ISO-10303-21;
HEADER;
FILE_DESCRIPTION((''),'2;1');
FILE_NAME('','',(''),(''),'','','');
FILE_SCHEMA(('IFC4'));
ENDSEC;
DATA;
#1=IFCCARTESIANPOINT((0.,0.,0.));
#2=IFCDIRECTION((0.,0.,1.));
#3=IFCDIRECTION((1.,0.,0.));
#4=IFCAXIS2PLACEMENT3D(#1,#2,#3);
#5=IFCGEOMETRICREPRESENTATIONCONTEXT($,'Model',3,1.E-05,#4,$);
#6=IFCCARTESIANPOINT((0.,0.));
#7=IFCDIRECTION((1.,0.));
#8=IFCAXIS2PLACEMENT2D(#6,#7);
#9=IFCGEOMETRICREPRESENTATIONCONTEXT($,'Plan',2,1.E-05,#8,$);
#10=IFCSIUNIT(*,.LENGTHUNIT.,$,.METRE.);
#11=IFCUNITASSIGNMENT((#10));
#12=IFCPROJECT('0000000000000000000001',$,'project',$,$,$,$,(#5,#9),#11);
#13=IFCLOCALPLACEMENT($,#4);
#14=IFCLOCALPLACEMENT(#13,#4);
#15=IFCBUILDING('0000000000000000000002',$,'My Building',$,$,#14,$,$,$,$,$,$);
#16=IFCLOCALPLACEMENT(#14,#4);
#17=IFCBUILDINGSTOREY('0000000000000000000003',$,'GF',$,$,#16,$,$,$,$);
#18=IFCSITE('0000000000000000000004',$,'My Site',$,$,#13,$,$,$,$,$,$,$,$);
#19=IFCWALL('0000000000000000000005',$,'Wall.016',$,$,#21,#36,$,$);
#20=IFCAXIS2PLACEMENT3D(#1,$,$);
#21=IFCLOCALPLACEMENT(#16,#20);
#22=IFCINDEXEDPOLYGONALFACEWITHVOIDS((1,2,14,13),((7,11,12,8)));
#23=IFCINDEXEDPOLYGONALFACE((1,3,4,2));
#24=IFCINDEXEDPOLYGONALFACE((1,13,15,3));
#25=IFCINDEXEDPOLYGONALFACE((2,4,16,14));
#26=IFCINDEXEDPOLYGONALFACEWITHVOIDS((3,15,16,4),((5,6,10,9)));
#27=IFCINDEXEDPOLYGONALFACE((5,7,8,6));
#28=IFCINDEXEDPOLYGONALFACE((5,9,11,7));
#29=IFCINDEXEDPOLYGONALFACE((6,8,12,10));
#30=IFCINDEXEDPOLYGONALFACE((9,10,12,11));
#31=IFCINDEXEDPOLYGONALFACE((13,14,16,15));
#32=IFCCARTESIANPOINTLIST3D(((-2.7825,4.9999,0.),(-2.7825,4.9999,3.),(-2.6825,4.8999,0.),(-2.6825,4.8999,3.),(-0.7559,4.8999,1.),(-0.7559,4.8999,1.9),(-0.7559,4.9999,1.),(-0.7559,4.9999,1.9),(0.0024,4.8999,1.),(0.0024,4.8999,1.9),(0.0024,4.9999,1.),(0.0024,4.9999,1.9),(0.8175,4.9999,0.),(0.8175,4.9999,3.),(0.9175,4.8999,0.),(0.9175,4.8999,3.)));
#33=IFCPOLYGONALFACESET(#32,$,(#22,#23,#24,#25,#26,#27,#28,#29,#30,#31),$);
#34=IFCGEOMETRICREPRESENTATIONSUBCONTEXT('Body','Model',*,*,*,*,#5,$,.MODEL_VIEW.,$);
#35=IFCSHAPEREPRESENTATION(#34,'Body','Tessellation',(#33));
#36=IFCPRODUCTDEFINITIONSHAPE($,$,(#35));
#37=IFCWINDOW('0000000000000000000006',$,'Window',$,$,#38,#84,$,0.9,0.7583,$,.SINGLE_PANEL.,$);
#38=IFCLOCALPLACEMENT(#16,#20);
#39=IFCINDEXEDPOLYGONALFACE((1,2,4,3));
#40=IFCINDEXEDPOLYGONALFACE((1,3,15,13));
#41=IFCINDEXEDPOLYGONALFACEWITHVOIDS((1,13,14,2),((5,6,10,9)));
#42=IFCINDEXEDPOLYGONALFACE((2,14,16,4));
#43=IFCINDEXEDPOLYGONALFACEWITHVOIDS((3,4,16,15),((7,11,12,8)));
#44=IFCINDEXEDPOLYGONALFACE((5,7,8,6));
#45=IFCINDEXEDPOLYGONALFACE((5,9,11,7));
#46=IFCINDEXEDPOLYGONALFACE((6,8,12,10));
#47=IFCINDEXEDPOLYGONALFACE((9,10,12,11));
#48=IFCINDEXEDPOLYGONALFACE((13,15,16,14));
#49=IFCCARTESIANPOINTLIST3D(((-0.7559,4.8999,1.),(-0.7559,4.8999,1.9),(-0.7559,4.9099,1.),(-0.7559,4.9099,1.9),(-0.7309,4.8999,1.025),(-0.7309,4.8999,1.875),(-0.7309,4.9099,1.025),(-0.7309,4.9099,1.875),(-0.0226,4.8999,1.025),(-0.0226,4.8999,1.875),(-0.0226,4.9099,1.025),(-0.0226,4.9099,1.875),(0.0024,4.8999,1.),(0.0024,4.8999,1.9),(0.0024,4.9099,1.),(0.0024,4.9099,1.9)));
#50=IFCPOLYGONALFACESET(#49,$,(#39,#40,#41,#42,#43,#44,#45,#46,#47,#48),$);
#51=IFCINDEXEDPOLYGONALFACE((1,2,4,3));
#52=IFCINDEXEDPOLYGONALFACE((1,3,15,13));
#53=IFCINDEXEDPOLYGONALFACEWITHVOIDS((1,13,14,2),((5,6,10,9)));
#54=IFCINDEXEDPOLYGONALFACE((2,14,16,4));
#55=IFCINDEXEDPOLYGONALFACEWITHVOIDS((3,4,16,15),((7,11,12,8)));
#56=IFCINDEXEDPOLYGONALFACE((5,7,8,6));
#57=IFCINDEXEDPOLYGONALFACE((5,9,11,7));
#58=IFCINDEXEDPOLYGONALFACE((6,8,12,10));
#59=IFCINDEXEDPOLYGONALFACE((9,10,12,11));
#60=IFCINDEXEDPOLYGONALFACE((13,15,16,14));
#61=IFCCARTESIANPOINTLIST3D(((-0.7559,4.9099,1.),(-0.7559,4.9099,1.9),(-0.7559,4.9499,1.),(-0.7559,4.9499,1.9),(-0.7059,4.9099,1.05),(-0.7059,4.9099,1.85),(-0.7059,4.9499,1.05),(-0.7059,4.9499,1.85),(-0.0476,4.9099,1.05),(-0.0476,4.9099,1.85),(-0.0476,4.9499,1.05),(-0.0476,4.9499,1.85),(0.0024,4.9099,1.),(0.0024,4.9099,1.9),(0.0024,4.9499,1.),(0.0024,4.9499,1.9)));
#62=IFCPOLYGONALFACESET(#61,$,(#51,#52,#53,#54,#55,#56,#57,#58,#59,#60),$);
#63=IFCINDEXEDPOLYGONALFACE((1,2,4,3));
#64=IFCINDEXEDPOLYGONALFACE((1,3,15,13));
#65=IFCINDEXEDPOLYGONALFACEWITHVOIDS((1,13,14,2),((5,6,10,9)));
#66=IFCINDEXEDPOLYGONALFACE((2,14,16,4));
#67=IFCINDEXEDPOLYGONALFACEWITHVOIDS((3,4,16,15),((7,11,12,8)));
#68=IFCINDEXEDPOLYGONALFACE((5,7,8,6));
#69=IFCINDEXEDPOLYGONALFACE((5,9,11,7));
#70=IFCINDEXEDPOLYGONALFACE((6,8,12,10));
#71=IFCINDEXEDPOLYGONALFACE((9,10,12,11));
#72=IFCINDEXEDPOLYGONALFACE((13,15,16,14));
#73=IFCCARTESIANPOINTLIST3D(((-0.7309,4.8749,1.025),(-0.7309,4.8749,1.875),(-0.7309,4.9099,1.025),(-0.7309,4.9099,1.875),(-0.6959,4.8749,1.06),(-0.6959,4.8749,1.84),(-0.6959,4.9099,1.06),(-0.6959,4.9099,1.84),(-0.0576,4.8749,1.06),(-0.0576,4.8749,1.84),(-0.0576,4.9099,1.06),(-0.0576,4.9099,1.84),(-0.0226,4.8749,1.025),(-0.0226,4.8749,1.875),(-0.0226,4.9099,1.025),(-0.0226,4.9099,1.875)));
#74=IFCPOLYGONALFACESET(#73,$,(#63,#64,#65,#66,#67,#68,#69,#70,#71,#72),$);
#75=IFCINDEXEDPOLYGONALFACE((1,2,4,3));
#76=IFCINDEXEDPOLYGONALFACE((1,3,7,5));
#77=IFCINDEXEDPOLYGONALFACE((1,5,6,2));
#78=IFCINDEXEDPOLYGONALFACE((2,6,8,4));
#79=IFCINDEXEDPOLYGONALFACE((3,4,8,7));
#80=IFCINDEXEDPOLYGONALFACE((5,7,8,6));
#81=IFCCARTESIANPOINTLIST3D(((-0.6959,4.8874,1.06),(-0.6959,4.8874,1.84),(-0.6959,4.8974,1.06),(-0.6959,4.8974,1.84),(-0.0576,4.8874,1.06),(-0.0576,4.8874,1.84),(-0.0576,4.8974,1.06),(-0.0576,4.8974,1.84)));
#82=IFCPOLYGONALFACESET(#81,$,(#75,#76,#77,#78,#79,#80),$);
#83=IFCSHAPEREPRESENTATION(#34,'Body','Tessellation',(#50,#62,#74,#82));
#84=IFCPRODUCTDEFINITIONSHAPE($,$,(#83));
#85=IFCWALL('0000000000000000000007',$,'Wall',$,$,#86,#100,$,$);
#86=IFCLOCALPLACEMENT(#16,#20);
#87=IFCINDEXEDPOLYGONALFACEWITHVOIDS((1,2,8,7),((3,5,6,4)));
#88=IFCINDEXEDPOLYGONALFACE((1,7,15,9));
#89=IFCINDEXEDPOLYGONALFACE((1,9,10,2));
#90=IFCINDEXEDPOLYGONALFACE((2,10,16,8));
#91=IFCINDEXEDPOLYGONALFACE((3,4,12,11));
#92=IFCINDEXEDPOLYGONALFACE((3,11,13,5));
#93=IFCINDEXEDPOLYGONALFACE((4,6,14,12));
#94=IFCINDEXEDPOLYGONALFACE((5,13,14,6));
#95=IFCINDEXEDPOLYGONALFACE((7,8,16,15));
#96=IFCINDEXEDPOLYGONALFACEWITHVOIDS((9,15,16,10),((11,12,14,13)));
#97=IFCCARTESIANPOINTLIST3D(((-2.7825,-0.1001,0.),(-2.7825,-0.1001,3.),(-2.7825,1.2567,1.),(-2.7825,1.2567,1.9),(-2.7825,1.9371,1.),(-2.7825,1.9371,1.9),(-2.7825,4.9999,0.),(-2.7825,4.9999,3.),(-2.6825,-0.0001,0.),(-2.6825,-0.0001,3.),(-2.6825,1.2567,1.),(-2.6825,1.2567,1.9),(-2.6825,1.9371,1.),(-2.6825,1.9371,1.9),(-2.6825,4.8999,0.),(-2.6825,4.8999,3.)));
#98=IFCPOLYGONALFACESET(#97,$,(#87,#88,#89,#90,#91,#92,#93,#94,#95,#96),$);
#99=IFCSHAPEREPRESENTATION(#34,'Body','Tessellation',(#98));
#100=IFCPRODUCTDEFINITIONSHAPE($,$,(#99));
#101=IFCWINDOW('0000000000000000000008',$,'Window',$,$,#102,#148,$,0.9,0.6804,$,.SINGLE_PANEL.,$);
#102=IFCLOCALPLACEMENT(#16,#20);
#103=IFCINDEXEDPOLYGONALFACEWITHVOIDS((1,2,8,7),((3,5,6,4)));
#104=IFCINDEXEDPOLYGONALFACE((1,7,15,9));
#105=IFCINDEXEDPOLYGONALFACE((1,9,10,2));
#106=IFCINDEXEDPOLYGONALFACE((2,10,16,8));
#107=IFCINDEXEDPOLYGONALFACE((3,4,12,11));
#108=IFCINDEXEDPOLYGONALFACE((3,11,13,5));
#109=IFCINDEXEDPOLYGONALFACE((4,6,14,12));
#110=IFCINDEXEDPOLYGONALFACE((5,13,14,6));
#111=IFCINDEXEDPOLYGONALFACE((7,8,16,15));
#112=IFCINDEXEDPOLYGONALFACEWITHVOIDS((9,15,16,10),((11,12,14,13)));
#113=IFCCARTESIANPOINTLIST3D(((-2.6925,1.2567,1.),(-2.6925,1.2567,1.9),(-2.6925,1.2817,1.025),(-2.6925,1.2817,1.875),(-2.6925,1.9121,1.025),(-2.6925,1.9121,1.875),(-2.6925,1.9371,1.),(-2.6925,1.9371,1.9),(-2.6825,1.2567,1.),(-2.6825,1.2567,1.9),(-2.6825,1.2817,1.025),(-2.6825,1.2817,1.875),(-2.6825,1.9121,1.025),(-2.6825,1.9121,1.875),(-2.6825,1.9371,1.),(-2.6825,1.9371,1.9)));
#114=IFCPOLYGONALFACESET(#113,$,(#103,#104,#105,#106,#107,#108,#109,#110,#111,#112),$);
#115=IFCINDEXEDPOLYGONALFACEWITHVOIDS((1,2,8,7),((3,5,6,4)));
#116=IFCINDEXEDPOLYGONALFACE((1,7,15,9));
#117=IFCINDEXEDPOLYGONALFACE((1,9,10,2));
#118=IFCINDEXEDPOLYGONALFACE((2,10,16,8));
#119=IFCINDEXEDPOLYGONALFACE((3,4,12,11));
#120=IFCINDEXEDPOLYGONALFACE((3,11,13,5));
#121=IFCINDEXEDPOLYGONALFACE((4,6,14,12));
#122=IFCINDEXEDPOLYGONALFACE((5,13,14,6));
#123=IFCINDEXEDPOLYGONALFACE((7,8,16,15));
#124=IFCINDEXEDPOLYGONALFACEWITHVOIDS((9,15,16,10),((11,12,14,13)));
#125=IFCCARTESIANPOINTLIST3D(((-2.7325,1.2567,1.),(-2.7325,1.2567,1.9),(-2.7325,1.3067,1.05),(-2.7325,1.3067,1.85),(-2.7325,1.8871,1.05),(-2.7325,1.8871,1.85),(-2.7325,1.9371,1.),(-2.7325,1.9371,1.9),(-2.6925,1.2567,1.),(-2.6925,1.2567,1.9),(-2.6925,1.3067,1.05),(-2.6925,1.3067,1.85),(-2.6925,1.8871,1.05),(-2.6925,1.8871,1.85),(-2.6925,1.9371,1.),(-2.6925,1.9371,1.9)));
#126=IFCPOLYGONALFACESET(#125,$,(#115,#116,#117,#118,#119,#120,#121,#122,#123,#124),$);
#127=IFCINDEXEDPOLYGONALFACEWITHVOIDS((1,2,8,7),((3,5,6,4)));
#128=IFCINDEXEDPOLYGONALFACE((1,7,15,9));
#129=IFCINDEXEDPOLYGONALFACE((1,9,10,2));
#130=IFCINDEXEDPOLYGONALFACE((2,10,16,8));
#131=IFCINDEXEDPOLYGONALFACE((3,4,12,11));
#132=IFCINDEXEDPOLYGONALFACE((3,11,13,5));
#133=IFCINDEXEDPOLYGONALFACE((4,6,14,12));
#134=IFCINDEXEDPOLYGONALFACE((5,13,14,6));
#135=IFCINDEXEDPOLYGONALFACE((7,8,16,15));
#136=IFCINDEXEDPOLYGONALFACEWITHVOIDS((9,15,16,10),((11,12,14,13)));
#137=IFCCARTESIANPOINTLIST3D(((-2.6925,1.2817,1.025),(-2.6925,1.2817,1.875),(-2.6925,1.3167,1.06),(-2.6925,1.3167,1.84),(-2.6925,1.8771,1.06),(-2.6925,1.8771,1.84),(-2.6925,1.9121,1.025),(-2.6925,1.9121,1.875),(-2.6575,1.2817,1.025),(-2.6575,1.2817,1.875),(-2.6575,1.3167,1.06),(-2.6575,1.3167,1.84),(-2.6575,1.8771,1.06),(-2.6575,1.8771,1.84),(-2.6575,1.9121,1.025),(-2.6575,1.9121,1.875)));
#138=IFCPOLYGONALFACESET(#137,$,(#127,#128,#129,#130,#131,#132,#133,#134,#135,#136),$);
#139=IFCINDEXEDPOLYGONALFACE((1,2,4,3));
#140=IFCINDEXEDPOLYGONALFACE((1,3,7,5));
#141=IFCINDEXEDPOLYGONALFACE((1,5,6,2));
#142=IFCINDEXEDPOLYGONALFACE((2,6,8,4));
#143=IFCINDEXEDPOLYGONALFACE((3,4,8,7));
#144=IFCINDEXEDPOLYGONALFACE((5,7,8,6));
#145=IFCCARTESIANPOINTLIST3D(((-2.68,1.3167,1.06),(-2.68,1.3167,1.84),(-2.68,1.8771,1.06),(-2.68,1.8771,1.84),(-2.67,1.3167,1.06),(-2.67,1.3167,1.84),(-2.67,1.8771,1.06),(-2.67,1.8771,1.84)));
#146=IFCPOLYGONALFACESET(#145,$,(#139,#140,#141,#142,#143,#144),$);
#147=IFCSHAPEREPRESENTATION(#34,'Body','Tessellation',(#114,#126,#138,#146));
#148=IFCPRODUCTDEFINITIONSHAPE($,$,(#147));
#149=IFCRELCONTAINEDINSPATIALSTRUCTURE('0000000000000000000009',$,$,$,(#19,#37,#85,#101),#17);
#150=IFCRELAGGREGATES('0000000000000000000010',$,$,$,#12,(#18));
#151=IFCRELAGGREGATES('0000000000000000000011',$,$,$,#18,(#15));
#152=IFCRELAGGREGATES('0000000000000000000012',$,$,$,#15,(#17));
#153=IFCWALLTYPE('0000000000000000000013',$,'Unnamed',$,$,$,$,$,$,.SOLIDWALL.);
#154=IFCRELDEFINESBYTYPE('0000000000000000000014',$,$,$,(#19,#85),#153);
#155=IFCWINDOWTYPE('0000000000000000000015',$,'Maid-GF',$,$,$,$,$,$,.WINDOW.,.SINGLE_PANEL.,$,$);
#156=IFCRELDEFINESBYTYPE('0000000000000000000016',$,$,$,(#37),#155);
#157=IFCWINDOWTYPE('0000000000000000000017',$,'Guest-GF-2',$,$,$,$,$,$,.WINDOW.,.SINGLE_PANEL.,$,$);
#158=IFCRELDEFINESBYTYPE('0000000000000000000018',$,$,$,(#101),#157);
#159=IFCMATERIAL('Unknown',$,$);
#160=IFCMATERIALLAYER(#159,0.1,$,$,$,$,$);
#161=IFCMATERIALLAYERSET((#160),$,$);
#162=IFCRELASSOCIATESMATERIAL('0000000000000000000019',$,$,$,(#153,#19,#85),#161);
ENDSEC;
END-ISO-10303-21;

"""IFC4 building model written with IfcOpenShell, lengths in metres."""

from ifc_helpers import new_model, entity, si_unit, frame, origin_with_axes, origin_2d_with_axis, place, context, subcontext, project, spatial, line, indexed_curve, outline, extrude, shape, source, transform, mapped, material, layer, layer_set, layer_usage, type_object, type_shapes, element, fill, save


model = new_model("IFC4")

# Units and contexts
model_context = context("Model", 3, precision=1e-05, world=origin_with_axes())
plan_context = context("Plan", 2, precision=1e-05, world=origin_2d_with_axis())
body_context_1 = subcontext(model_context, "Body", "Model", "MODEL_VIEW")
body_context_2 = subcontext(plan_context, "Body", "Plan", "PLAN_VIEW")
ifc_project = project(units=[si_unit("LENGTHUNIT", "METRE")], contexts=[model_context, plan_context])

# Site, building, storey
site_placement = place(None, origin_with_axes())
site = spatial("IfcSite", under=ifc_project, at=site_placement, Name="My Site")
building_placement = place(site_placement, origin_with_axes())
building = spatial("IfcBuilding", under=site, at=building_placement, Name="My Building")
storey_placement = place(building_placement, origin_with_axes())
storey = spatial("IfcBuildingStorey", under=building, at=storey_placement, Name="GF")

# Shared definitions
ifc_material = material(Name="Unknown")

# Shared definitions
ifc_layer_1 = layer(ifc_material, 0.1)
ifc_layer_set_1 = layer_set([ifc_layer_1])
wall_type = type_object("IfcWallType", Name="Unnamed", PredefinedType="SOLIDWALL", material=ifc_layer_set_1)

# Walls, openings, windows
ifc_layer_usage_1 = layer_usage(ifc_layer_set_1, "AXIS2", "POSITIVE", 0.0)
wall_1_placement = place(storey_placement, frame((0.8175, 4.9999, 0.0), z_axis=(0.0, 0.0, 1.0), x_axis=(-1.0, 0.0, 0.0)))
wall_1 = element("IfcWall", 1, at=wall_1_placement, inside=storey, type_object=wall_type, material=ifc_layer_usage_1, Name="Wall.016", context=body_context_1, shape_type="SweptSolid", body=[
    extrude(outline(indexed_curve([(0.0, 0.0), (-0.1, 0.1), (3.5, 0.1), (3.6, 0.0)], segments=[line(1, 2, 3, 4, 1)])), origin_with_axes(), (0.0, 0.0, 1.0), 3.0),
])
shared_shape_1 = source(origin_with_axes(), body_context_1, "Body", "SweptSolid", [
    extrude(outline(indexed_curve([(0.0, 0.0), (0.7583, 0.0), (0.7583, 0.9), (0.0, 0.9)], segments=[line(1, 2, 3, 4, 1)])), frame((0.0, -0.6, 0.0), z_axis=(0.0, -1.0, 0.0), x_axis=(1.0, 0.0, 0.0)), (0.0, 0.0, -1.0), 1.2),
])
opening_1_placement = place(wall_1_placement, frame((0.8151, 0.0, 1.0), z_axis=(0.0, 0.0, 1.0), x_axis=(1.0, 0.0, 0.0)))
opening_1 = element("IfcOpeningElement", 2, at=opening_1_placement, cuts=wall_1, PredefinedType="OPENING", context=body_context_1, shape_type="MappedRepresentation", body=[
    mapped(shared_shape_1, transform((0.0, 0.0, 0.0), x_axis=(1.0, 0.0, 0.0), y_axis=(0.0, 1.0, 0.0), z_axis=(0.0, 0.0, 1.0), scale=1.0)),
])
window_type_1 = type_object("IfcWindowType", Name="Maid-GF", PartitioningType="SINGLE_PANEL", PredefinedType="WINDOW")
shared_shape_2 = source(origin_with_axes(), body_context_1, "Body", "SweptSolid", [
    extrude(outline(indexed_curve([(0.0, 0.0), (0.7583, 0.0), (0.7583, 0.9), (0.0, 0.9)], segments=[line(1, 2, 3, 4, 1)]), holes=[indexed_curve([(0.025, 0.025), (0.7333, 0.025), (0.7333, 0.875), (0.025, 0.875)], segments=[line(1, 2, 3, 4, 1)])]), frame((0.0, 0.09, 0.0), z_axis=(0.0, -1.0, 0.0), x_axis=(1.0, 0.0, 0.0)), (0.0, 0.0, -1.0), 0.01),
    extrude(outline(indexed_curve([(0.0, 0.0), (0.7583, 0.0), (0.7583, 0.9), (0.0, 0.9)], segments=[line(1, 2, 3, 4, 1)]), holes=[indexed_curve([(0.05, 0.05), (0.7083, 0.05), (0.7083, 0.85), (0.05, 0.85)], segments=[line(1, 2, 3, 4, 1)])]), frame((0.0, 0.05, 0.0), z_axis=(0.0, -1.0, 0.0), x_axis=(1.0, 0.0, 0.0)), (0.0, 0.0, -1.0), 0.04),
    extrude(outline(indexed_curve([(0.0, 0.0), (0.7083, 0.0), (0.7083, 0.85), (0.0, 0.85)], segments=[line(1, 2, 3, 4, 1)]), holes=[indexed_curve([(0.035, 0.035), (0.6733, 0.035), (0.6733, 0.815), (0.035, 0.815)], segments=[line(1, 2, 3, 4, 1)])]), frame((0.025, 0.09, 0.025), z_axis=(0.0, -1.0, 0.0), x_axis=(1.0, 0.0, 0.0)), (0.0, 0.0, -1.0), 0.035),
    extrude(outline(indexed_curve([(0.035, 0.035), (0.6733, 0.035), (0.6733, 0.815), (0.035, 0.815)], segments=[line(1, 2, 3, 4, 1)])), frame((0.025, 0.1025, 0.025), z_axis=(0.0, -1.0, 0.0), x_axis=(1.0, 0.0, 0.0)), (0.0, 0.0, -1.0), 0.01),
])
shared_shape_3 = source(origin_with_axes(), body_context_2, "Body", "Curve2D", [
    entity("IfcIndexedPolyCurve", entity("IfcCartesianPointList2D", [[0.05, 0.05], [0.7083, 0.05]])),
    entity("IfcIndexedPolyCurve", entity("IfcCartesianPointList2D", [[0.0, 0.1], [0.025, 0.1], [0.025, 0.09], [0.05, 0.09], [0.05, 0.05], [0.0, 0.05]]), [entity("IfcLineIndex", [1, 2, 3, 4, 5, 6, 1])]),
    entity("IfcIndexedPolyCurve", entity("IfcCartesianPointList2D", [[0.7583, 0.1], [0.7333, 0.1], [0.7333, 0.09], [0.7083, 0.09], [0.7083, 0.05], [0.7583, 0.05]]), [entity("IfcLineIndex", [1, 2, 3, 4, 5, 6, 1])]),
    entity("IfcIndexedPolyCurve", entity("IfcCartesianPointList2D", [[0.025, 0.09], [0.06, 0.09], [0.06, 0.125], [0.025, 0.125]]), [entity("IfcLineIndex", [1, 2, 3, 4, 1])]),
    entity("IfcIndexedPolyCurve", entity("IfcCartesianPointList2D", [[0.7333, 0.09], [0.6983, 0.09], [0.6983, 0.125], [0.7333, 0.125]]), [entity("IfcLineIndex", [1, 2, 3, 4, 1])]),
    entity("IfcIndexedPolyCurve", entity("IfcCartesianPointList2D", [[0.06, 0.09], [0.6983, 0.09]])),
    entity("IfcIndexedPolyCurve", entity("IfcCartesianPointList2D", [[0.06, 0.125], [0.6983, 0.125]])),
    entity("IfcIndexedPolyCurve", entity("IfcCartesianPointList2D", [[0.06, 0.1075], [0.6983, 0.1075]])),
])
type_shapes(window_type_1, [shared_shape_2, shared_shape_3])
window_1_placement = place(opening_1_placement, frame((0.0, 0.0, 0.0), z_axis=(0.0, 0.0, 1.0), x_axis=(1.0, 0.0, 0.0)))
window_1 = element("IfcWindow", 3, at=window_1_placement, inside=storey, type_object=window_type_1, Name="Window", OverallHeight=0.9, OverallWidth=0.7583, PartitioningType="SINGLE_PANEL", shapes=[
    shape(body_context_1, "Body", "MappedRepresentation", [mapped(shared_shape_2, transform((0.0, 0.0, 0.0), x_axis=(1.0, 0.0, 0.0), y_axis=(0.0, 1.0, 0.0), z_axis=(0.0, 0.0, 1.0), scale=1.0))]),
    shape(body_context_2, "Body", "MappedRepresentation", [mapped(shared_shape_3, transform((0.0, 0.0, 0.0), x_axis=(1.0, 0.0, 0.0), y_axis=(0.0, 1.0, 0.0), z_axis=(0.0, 0.0, 1.0), scale=1.0))]),
])
fill(opening_1, window_1)
ifc_layer_usage_2 = layer_usage(ifc_layer_set_1, "AXIS2", "POSITIVE", 0.0)
wall_2_placement = place(storey_placement, frame((-2.7825, 4.9999, 0.0), z_axis=(0.0, 0.0, 1.0), x_axis=(0.0, -1.0, 0.0)))
wall_2 = element("IfcWall", 4, at=wall_2_placement, inside=storey, type_object=wall_type, material=ifc_layer_usage_2, Name="Wall", context=body_context_1, shape_type="SweptSolid", body=[
    extrude(outline(indexed_curve([(0.0, 0.0), (0.1, 0.1), (5.0, 0.1), (5.1, 0.0)], segments=[line(1, 2, 3, 4, 1)])), origin_with_axes(), (0.0, 0.0, 1.0), 3.0),
])
shared_shape_4 = source(origin_with_axes(), body_context_1, "Body", "SweptSolid", [
    extrude(outline(indexed_curve([(0.0, 0.0), (0.6804, 0.0), (0.6804, 0.9), (0.0, 0.9)], segments=[line(1, 2, 3, 4, 1)])), frame((0.0, -0.6, 0.0), z_axis=(0.0, -1.0, 0.0), x_axis=(1.0, 0.0, 0.0)), (0.0, 0.0, -1.0), 1.2),
])
opening_2_placement = place(wall_2_placement, frame((3.0629, 0.0, 1.0), z_axis=(0.0, 0.0, 1.0), x_axis=(1.0, 0.0, 0.0)))
opening_2 = element("IfcOpeningElement", 5, at=opening_2_placement, cuts=wall_2, PredefinedType="OPENING", context=body_context_1, shape_type="MappedRepresentation", body=[
    mapped(shared_shape_4, transform((0.0, 0.0, 0.0), x_axis=(1.0, 0.0, 0.0), y_axis=(0.0, 1.0, 0.0), z_axis=(0.0, 0.0, 1.0), scale=1.0)),
])
window_type_2 = type_object("IfcWindowType", Name="Guest-GF-2", PartitioningType="SINGLE_PANEL", PredefinedType="WINDOW")
shared_shape_5 = source(origin_with_axes(), body_context_1, "Body", "SweptSolid", [
    extrude(outline(indexed_curve([(0.0, 0.0), (0.6804, 0.0), (0.6804, 0.9), (0.0, 0.9)], segments=[line(1, 2, 3, 4, 1)]), holes=[indexed_curve([(0.025, 0.025), (0.6554, 0.025), (0.6554, 0.875), (0.025, 0.875)], segments=[line(1, 2, 3, 4, 1)])]), frame((0.0, 0.09, 0.0), z_axis=(0.0, -1.0, 0.0), x_axis=(1.0, 0.0, 0.0)), (0.0, 0.0, -1.0), 0.01),
    extrude(outline(indexed_curve([(0.0, 0.0), (0.6804, 0.0), (0.6804, 0.9), (0.0, 0.9)], segments=[line(1, 2, 3, 4, 1)]), holes=[indexed_curve([(0.05, 0.05), (0.6304, 0.05), (0.6304, 0.85), (0.05, 0.85)], segments=[line(1, 2, 3, 4, 1)])]), frame((0.0, 0.05, 0.0), z_axis=(0.0, -1.0, 0.0), x_axis=(1.0, 0.0, 0.0)), (0.0, 0.0, -1.0), 0.04),
    extrude(outline(indexed_curve([(0.0, 0.0), (0.6304, 0.0), (0.6304, 0.85), (0.0, 0.85)], segments=[line(1, 2, 3, 4, 1)]), holes=[indexed_curve([(0.035, 0.035), (0.5954, 0.035), (0.5954, 0.815), (0.035, 0.815)], segments=[line(1, 2, 3, 4, 1)])]), frame((0.025, 0.09, 0.025), z_axis=(0.0, -1.0, 0.0), x_axis=(1.0, 0.0, 0.0)), (0.0, 0.0, -1.0), 0.035),
    extrude(outline(indexed_curve([(0.035, 0.035), (0.5954, 0.035), (0.5954, 0.815), (0.035, 0.815)], segments=[line(1, 2, 3, 4, 1)])), frame((0.025, 0.1025, 0.025), z_axis=(0.0, -1.0, 0.0), x_axis=(1.0, 0.0, 0.0)), (0.0, 0.0, -1.0), 0.01),
])
shared_shape_6 = source(origin_with_axes(), body_context_2, "Body", "Curve2D", [
    entity("IfcIndexedPolyCurve", entity("IfcCartesianPointList2D", [[0.05, 0.05], [0.6304, 0.05]])),
    entity("IfcIndexedPolyCurve", entity("IfcCartesianPointList2D", [[0.0, 0.1], [0.025, 0.1], [0.025, 0.09], [0.05, 0.09], [0.05, 0.05], [0.0, 0.05]]), [entity("IfcLineIndex", [1, 2, 3, 4, 5, 6, 1])]),
    entity("IfcIndexedPolyCurve", entity("IfcCartesianPointList2D", [[0.6804, 0.1], [0.6554, 0.1], [0.6554, 0.09], [0.6304, 0.09], [0.6304, 0.05], [0.6804, 0.05]]), [entity("IfcLineIndex", [1, 2, 3, 4, 5, 6, 1])]),
    entity("IfcIndexedPolyCurve", entity("IfcCartesianPointList2D", [[0.025, 0.09], [0.06, 0.09], [0.06, 0.125], [0.025, 0.125]]), [entity("IfcLineIndex", [1, 2, 3, 4, 1])]),
    entity("IfcIndexedPolyCurve", entity("IfcCartesianPointList2D", [[0.6554, 0.09], [0.6204, 0.09], [0.6204, 0.125], [0.6554, 0.125]]), [entity("IfcLineIndex", [1, 2, 3, 4, 1])]),
    entity("IfcIndexedPolyCurve", entity("IfcCartesianPointList2D", [[0.06, 0.09], [0.6204, 0.09]])),
    entity("IfcIndexedPolyCurve", entity("IfcCartesianPointList2D", [[0.06, 0.125], [0.6204, 0.125]])),
    entity("IfcIndexedPolyCurve", entity("IfcCartesianPointList2D", [[0.06, 0.1075], [0.6204, 0.1075]])),
])
type_shapes(window_type_2, [shared_shape_5, shared_shape_6])
window_2_placement = place(opening_2_placement, origin_with_axes())
window_2 = element("IfcWindow", 6, at=window_2_placement, inside=storey, type_object=window_type_2, Name="Window", OverallHeight=0.9, OverallWidth=0.6804, PartitioningType="SINGLE_PANEL", shapes=[
    shape(body_context_1, "Body", "MappedRepresentation", [mapped(shared_shape_5, transform((0.0, 0.0, 0.0), x_axis=(1.0, 0.0, 0.0), y_axis=(0.0, 1.0, 0.0), z_axis=(0.0, 0.0, 1.0), scale=1.0))]),
    shape(body_context_2, "Body", "MappedRepresentation", [mapped(shared_shape_6, transform((0.0, 0.0, 0.0), x_axis=(1.0, 0.0, 0.0), y_axis=(0.0, 1.0, 0.0), z_axis=(0.0, 0.0, 1.0), scale=1.0))]),
])
fill(opening_2, window_2)

save(model, "model.ifc")
